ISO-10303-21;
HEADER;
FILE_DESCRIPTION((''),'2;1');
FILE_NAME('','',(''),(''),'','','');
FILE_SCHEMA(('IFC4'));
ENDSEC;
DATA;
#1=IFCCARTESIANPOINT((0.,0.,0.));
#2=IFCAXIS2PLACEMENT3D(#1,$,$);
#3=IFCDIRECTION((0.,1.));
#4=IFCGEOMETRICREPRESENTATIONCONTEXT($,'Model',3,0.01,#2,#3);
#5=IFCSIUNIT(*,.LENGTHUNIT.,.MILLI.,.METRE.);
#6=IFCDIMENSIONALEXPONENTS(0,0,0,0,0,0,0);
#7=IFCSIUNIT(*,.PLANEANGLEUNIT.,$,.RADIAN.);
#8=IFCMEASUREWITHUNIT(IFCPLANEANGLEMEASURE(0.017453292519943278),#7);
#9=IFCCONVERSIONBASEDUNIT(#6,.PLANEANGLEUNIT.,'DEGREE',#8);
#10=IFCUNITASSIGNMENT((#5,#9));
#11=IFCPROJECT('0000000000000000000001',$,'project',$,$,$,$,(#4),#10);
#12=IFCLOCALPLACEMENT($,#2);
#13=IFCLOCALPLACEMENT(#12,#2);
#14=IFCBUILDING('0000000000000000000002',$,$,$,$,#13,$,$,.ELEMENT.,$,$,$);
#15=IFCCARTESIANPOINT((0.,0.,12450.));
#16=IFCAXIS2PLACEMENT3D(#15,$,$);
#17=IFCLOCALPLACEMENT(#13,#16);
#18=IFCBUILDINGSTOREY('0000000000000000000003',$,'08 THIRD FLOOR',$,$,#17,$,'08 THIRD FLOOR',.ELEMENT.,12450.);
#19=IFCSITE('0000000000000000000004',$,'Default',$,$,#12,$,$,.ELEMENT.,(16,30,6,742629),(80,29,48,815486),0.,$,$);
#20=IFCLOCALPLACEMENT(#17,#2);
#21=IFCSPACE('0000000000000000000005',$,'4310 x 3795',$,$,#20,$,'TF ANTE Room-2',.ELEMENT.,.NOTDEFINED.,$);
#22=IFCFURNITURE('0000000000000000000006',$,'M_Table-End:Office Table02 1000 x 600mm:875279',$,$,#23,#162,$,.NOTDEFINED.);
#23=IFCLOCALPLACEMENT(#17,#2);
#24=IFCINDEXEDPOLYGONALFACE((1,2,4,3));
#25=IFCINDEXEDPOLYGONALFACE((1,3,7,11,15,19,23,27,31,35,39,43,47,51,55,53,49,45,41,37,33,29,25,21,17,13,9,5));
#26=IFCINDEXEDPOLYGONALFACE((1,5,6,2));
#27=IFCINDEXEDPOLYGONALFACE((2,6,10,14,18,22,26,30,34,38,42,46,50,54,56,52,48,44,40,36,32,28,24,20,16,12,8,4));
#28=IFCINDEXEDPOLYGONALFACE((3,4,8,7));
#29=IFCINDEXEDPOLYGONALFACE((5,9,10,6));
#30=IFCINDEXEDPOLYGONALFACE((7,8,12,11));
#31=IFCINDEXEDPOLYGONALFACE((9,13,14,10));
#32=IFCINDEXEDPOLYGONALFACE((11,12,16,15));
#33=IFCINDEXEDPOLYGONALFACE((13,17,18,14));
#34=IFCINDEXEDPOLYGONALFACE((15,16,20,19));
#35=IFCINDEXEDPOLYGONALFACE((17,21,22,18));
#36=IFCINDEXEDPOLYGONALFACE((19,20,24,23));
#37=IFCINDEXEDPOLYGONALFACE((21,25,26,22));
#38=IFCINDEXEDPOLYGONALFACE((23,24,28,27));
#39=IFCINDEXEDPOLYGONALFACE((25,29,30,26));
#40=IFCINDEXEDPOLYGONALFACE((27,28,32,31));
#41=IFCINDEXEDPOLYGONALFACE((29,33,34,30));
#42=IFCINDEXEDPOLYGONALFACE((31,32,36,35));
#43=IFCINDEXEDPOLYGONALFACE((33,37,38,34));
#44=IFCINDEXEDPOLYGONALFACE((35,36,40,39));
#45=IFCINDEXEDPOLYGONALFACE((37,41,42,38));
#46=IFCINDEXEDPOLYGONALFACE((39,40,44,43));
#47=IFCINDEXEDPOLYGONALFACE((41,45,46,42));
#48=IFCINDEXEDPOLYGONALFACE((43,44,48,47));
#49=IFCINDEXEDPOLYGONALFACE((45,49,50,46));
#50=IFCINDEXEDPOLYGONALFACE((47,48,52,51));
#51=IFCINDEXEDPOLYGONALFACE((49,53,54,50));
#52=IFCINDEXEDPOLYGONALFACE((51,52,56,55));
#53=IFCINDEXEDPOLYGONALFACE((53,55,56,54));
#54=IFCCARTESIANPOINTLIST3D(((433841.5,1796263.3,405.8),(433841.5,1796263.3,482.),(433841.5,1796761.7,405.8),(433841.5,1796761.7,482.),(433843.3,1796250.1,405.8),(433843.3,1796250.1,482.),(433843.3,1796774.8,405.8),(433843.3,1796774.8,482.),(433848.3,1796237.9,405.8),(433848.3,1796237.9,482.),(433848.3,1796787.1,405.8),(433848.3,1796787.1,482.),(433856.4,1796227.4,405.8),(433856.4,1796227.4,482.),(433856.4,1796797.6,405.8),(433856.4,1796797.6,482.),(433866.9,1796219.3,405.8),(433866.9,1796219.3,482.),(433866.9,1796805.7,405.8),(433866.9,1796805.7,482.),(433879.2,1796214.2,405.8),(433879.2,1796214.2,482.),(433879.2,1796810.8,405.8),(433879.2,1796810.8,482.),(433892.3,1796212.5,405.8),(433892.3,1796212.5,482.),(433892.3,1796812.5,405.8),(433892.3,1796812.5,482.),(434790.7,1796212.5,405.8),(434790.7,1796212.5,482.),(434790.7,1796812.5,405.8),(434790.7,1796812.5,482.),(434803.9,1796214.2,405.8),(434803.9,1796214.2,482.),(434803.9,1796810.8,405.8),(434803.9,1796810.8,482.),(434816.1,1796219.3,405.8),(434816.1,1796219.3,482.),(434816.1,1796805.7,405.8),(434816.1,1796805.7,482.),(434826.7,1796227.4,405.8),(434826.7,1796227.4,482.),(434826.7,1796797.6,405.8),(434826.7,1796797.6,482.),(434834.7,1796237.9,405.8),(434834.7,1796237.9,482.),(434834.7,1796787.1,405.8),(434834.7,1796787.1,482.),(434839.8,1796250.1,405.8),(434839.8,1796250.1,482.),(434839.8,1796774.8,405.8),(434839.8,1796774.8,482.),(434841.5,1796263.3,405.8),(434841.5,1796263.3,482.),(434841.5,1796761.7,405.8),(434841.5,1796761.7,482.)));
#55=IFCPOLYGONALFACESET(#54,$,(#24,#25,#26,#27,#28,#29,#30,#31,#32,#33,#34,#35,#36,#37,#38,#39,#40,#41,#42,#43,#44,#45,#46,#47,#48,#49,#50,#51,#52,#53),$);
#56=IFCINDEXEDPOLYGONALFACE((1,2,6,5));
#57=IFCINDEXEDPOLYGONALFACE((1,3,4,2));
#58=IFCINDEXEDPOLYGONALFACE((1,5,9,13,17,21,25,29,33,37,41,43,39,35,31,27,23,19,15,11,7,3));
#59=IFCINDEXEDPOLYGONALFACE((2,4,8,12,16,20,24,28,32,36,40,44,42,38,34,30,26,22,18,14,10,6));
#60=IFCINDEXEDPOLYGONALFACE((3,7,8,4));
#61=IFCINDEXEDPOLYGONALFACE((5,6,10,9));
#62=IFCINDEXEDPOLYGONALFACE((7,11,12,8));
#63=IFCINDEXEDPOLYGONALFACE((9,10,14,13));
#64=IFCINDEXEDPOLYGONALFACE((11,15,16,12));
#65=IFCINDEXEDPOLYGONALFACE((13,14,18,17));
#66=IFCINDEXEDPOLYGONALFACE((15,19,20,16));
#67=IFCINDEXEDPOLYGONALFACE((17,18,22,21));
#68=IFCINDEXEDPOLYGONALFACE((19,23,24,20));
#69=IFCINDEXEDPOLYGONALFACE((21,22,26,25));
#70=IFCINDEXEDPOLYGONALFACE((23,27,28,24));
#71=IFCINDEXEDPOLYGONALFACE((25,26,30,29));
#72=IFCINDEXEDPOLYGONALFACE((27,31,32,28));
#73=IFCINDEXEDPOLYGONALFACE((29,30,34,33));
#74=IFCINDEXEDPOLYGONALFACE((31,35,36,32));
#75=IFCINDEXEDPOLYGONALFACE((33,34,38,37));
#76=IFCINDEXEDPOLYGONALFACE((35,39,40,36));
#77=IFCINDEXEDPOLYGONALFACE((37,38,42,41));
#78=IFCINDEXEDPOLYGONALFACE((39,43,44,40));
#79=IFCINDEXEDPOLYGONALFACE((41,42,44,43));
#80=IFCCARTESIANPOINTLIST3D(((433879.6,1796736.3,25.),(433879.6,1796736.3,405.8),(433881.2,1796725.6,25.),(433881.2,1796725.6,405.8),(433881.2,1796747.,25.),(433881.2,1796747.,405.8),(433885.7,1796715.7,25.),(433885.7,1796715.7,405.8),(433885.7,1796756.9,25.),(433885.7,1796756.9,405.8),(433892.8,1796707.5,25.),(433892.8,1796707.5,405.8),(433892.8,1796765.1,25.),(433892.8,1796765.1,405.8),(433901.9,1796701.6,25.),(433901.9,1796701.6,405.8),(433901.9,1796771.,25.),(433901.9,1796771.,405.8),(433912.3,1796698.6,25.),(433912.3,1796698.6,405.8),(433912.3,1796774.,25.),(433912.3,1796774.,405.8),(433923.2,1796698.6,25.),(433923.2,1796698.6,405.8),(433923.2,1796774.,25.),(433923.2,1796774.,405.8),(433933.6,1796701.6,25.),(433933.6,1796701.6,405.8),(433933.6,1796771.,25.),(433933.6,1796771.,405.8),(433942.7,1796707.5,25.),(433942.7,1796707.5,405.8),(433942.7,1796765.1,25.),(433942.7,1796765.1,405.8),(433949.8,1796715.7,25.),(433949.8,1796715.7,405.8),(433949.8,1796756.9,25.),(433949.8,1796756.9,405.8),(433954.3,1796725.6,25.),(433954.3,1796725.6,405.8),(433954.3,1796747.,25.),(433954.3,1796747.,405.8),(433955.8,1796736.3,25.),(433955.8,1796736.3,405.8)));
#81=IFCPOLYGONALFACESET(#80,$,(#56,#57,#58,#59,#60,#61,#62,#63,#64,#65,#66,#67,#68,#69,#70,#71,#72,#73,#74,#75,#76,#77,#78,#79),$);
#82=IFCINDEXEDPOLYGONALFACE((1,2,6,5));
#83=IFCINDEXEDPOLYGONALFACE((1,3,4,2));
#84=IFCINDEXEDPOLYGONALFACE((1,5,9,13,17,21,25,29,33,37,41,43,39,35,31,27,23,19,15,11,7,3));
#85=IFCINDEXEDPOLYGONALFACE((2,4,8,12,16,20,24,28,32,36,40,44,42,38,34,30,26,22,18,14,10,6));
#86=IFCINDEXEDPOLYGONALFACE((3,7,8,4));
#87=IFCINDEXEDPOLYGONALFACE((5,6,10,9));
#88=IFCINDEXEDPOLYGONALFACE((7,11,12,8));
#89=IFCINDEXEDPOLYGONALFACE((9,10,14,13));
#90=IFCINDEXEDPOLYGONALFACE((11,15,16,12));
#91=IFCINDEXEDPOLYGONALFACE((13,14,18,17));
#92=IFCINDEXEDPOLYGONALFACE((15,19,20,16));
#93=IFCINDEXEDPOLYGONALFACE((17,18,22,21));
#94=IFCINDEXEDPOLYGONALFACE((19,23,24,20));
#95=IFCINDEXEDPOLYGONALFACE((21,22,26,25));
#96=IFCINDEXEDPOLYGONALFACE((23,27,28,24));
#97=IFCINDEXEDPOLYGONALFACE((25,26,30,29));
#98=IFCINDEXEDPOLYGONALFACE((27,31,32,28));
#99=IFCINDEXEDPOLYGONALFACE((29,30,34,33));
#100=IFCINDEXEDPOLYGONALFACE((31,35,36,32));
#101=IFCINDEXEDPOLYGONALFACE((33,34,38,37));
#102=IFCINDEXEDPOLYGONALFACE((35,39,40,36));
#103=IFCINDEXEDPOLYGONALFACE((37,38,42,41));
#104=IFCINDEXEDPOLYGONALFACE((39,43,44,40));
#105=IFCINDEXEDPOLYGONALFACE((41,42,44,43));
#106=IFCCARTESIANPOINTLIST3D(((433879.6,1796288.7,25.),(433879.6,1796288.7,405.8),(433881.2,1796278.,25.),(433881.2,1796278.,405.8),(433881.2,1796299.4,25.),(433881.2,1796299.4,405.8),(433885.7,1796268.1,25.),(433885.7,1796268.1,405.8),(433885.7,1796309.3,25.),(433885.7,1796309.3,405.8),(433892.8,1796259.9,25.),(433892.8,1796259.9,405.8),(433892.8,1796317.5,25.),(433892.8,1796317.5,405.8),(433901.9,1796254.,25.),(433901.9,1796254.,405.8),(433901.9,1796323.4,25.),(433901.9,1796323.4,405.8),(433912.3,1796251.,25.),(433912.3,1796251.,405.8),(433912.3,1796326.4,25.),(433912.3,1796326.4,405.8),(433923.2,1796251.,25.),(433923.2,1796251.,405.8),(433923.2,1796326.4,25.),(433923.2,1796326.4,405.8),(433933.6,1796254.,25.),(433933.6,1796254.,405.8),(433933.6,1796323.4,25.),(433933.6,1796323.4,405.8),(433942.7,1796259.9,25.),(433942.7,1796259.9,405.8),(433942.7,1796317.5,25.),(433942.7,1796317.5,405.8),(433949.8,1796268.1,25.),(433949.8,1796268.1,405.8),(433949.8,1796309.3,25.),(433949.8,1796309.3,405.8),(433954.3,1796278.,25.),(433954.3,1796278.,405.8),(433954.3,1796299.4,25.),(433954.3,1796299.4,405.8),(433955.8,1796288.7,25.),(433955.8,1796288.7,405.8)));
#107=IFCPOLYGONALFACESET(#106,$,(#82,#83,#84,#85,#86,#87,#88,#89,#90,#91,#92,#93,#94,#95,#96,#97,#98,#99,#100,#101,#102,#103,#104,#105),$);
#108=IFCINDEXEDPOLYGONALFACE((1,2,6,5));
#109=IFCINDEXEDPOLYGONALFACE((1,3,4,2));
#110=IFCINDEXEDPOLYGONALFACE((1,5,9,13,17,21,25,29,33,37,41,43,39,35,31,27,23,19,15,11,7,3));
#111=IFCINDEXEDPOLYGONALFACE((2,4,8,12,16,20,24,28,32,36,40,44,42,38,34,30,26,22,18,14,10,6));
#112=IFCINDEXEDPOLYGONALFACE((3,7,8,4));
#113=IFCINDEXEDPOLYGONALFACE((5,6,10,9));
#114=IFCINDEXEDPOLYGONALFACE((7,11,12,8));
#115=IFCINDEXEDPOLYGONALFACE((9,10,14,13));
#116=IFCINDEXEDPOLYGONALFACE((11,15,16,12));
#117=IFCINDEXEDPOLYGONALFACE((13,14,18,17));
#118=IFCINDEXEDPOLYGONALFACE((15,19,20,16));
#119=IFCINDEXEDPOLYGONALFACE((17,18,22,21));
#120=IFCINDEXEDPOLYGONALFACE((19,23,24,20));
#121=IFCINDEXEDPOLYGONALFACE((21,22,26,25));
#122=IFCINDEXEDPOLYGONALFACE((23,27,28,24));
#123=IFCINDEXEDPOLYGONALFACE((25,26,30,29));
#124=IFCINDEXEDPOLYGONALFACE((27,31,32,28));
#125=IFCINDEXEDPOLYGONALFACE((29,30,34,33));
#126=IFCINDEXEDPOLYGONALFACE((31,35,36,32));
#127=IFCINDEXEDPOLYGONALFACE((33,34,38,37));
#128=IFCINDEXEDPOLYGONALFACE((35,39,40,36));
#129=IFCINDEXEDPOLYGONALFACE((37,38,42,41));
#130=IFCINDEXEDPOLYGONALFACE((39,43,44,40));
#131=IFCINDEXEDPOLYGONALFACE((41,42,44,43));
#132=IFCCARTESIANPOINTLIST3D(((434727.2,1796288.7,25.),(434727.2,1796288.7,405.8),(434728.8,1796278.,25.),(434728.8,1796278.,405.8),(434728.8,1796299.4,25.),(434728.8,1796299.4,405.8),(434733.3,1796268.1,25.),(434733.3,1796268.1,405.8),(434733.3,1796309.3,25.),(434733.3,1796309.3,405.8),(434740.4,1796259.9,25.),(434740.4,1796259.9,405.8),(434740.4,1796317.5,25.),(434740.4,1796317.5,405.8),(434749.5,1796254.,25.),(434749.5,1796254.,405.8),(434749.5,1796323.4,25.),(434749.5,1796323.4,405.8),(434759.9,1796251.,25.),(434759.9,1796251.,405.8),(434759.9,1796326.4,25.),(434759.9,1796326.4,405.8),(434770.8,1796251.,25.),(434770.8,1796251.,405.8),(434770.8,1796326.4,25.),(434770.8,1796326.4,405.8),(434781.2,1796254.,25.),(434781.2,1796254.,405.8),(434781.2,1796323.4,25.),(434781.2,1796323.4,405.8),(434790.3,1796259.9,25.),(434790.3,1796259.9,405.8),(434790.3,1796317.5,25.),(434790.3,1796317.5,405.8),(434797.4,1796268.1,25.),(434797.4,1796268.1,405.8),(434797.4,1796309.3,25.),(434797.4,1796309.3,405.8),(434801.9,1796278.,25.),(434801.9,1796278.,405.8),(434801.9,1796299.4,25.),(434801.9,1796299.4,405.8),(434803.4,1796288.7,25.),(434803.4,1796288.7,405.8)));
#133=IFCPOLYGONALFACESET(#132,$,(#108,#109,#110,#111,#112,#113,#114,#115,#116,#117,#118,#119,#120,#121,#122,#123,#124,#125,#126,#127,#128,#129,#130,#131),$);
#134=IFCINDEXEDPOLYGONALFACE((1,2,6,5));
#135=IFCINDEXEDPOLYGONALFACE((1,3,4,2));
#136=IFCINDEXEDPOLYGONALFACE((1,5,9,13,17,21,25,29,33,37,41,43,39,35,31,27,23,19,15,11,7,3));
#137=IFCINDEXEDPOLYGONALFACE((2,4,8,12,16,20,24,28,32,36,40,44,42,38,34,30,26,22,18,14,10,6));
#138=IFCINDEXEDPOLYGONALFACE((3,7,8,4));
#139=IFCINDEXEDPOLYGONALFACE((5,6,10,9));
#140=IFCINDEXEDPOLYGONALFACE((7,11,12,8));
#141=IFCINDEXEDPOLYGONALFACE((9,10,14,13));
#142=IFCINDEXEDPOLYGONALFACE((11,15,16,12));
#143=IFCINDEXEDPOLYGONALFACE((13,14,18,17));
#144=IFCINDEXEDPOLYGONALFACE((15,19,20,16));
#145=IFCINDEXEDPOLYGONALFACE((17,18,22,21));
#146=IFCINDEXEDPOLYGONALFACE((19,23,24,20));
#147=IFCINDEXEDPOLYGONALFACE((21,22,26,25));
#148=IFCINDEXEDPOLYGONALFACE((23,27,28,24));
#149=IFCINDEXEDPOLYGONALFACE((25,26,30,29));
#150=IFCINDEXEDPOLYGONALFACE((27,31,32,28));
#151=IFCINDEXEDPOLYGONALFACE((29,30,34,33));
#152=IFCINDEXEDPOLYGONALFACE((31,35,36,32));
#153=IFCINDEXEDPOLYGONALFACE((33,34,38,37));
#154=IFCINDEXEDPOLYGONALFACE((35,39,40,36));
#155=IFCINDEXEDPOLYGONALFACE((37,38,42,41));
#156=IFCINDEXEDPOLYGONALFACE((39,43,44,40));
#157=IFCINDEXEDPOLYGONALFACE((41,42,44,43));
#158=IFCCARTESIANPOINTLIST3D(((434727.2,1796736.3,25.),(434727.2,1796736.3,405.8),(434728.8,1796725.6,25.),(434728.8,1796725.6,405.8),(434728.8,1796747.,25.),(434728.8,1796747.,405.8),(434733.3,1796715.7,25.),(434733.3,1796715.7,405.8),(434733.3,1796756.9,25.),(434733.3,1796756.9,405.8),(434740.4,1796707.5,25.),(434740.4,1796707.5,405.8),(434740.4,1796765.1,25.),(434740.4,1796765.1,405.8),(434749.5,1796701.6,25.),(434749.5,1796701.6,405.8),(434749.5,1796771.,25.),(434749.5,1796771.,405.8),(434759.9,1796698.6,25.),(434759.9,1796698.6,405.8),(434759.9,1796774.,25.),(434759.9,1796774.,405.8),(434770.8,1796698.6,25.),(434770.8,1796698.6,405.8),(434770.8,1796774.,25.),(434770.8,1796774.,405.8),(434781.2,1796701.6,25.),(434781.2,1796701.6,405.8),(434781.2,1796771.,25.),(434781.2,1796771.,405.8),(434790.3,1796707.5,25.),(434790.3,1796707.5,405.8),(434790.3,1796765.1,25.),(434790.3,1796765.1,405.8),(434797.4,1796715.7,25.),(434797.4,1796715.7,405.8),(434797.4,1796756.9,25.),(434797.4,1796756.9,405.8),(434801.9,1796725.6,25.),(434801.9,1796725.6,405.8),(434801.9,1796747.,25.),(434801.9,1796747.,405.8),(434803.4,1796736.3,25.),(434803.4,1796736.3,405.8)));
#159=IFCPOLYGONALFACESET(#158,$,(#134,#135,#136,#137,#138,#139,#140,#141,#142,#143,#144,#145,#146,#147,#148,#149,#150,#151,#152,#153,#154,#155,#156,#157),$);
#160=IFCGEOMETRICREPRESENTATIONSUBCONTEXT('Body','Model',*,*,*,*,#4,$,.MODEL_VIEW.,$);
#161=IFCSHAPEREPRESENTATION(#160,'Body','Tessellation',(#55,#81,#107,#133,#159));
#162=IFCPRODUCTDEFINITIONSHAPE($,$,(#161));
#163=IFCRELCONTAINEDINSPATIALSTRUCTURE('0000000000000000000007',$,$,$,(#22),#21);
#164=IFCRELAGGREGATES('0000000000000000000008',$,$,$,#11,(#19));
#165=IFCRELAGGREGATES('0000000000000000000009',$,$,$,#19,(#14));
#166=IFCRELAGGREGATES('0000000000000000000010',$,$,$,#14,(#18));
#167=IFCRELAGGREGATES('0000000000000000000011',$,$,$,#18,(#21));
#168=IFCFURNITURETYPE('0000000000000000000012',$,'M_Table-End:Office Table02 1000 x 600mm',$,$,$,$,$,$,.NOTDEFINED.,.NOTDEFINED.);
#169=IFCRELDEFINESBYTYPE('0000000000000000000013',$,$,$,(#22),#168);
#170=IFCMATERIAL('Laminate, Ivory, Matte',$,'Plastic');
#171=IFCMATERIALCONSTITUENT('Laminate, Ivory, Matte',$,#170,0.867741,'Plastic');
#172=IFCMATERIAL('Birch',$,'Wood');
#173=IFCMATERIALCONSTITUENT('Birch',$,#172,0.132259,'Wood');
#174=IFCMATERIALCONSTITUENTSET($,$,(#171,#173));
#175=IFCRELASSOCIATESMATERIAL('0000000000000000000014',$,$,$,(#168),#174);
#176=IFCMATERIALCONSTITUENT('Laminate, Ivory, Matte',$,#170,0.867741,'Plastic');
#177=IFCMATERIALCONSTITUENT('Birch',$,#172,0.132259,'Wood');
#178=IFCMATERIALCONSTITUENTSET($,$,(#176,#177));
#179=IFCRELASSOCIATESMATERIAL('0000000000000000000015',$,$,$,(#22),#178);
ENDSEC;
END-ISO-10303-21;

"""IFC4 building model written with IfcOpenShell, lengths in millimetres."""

from ifc_helpers import new_model, entity, si_unit, converted_unit, direction, frame, origin, place, context, subcontext, project, spatial, line, arc, indexed_curve, outline, extrude, source, transform, mapped, material, constituent, constituent_set, type_object, type_shapes, element, save


model = new_model("IFC4")

# Units and contexts
model_context = context("Model", 3, precision=0.01, world=origin(), true_north=direction((0.0, 1.0)))
body_context = subcontext(model_context, "Body", "Model", "MODEL_VIEW")
ifc_project = project(units=[si_unit("LENGTHUNIT", "METRE", prefix="MILLI"), converted_unit("PLANEANGLEUNIT", "DEGREE", entity("IfcPlaneAngleMeasure", 0.017453292519943278), si_unit("PLANEANGLEUNIT", "RADIAN"), dimensions=[0, 0, 0, 0, 0, 0, 0])], contexts=[model_context])

# Site, building, storey
site_placement = place(None, origin())
site = spatial("IfcSite", under=ifc_project, at=site_placement, Name="Default", CompositionType="ELEMENT", RefLatitude=(16, 30, 6, 742629), RefLongitude=(80, 29, 48, 815486), RefElevation=0.0)
building_placement = place(site_placement, origin())
building = spatial("IfcBuilding", under=site, at=building_placement, CompositionType="ELEMENT")
storey_placement = place(building_placement, frame((0.0, 0.0, 12450.0)))
storey = spatial("IfcBuildingStorey", under=building, at=storey_placement, Name="08 THIRD FLOOR", LongName="08 THIRD FLOOR", CompositionType="ELEMENT", Elevation=12450.0)

# Shared definitions
space_1_placement = place(storey_placement, origin())
space_1 = spatial("IfcSpace", under=storey, at=space_1_placement, Name="4310 x 3795", LongName="TF ANTE Room-2", CompositionType="ELEMENT", PredefinedType="NOTDEFINED")

# Furniture
ifc_material_1 = material(Name="Laminate, Ivory, Matte", Category="Plastic")
ifc_material_2 = material(Name="Birch", Category="Wood")
ifc_constituent_1 = constituent(ifc_material_1, Name="Laminate, Ivory, Matte", Category="Plastic", fraction=0.867741)
ifc_constituent_2 = constituent(ifc_material_2, Name="Birch", Category="Wood", fraction=0.132259)
ifc_constituent_set_1 = constituent_set(constituents=[ifc_constituent_1, ifc_constituent_2])
ifc_constituent_3 = constituent(ifc_material_1, Name="Laminate, Ivory, Matte", Category="Plastic", fraction=0.867741)
ifc_constituent_4 = constituent(ifc_material_2, Name="Birch", Category="Wood", fraction=0.132259)
ifc_constituent_set_2 = constituent_set(constituents=[ifc_constituent_3, ifc_constituent_4])
furniture_type_1 = type_object("IfcFurnitureType", Name="M_Table-End:Office Table02 1000 x 600mm", AssemblyPlace="NOTDEFINED", PredefinedType="NOTDEFINED", material=ifc_constituent_set_2)
shared_shape_1 = source(origin(), body_context, "Body", "SweptSolid", [
    extrude(outline(indexed_curve([(449.2, -300.0), (485.1, -285.1), (500.0, -249.2), (500.0, 249.2), (485.1, 285.1), (449.2, 300.0), (-449.2, 300.0), (-485.1, 285.1), (-500.0, 249.2), (-500.0, -249.2), (-485.1, -285.1), (-449.2, -300.0)], segments=[arc(1, 2, 3), line(3, 4), arc(4, 5, 6), line(6, 7), arc(7, 8, 9), line(9, 10), arc(10, 11, 12), line(12, 1)], self_intersect=False)), frame((503.7, 152.4, 405.8)), (0.0, 0.0, 1.0), 76.2),
    extrude(outline(indexed_curve([(-38.1, 0.0), (0.0, -38.1), (38.1, 0.0), (0.0, 38.1)], segments=[arc(1, 2, 3), arc(3, 4, 1)], self_intersect=False)), frame((927.5, -71.4, 25.0)), (0.0, 0.0, 1.0), 380.8),
    extrude(outline(indexed_curve([(-38.1, 0.0), (0.0, -38.1), (38.1, 0.0), (0.0, 38.1)], segments=[arc(1, 2, 3), arc(3, 4, 1)], self_intersect=False)), frame((927.5, 376.2, 25.0)), (0.0, 0.0, 1.0), 380.8),
    extrude(outline(indexed_curve([(-38.1, 0.0), (0.0, -38.1), (38.1, 0.0), (0.0, 38.1)], segments=[arc(1, 2, 3), arc(3, 4, 1)], self_intersect=False)), frame((79.9, 376.2, 25.0)), (0.0, 0.0, 1.0), 380.8),
    extrude(outline(indexed_curve([(-38.1, 0.0), (0.0, -38.1), (38.1, 0.0), (0.0, 38.1)], segments=[arc(1, 2, 3), arc(3, 4, 1)], self_intersect=False)), frame((79.9, -71.4, 25.0)), (0.0, 0.0, 1.0), 380.8),
])
type_shapes(furniture_type_1, [shared_shape_1])
furniture_1_placement = place(space_1_placement, frame((434845.3, 1796664.9, 0.0), z_axis=(0.0, 0.0, 1.0), x_axis=(-1.0, 0.0, 0.0)))
element("IfcFurniture", 1, at=furniture_1_placement, inside=space_1, type_object=furniture_type_1, material=ifc_constituent_set_1, Name="M_Table-End:Office Table02 1000 x 600mm:875279", PredefinedType="NOTDEFINED", context=body_context, shape_type="MappedRepresentation", body=[
    mapped(shared_shape_1, transform((0.0, 0.0, 0.0), scale=1.0)),
])

save(model, "model.ifc")
